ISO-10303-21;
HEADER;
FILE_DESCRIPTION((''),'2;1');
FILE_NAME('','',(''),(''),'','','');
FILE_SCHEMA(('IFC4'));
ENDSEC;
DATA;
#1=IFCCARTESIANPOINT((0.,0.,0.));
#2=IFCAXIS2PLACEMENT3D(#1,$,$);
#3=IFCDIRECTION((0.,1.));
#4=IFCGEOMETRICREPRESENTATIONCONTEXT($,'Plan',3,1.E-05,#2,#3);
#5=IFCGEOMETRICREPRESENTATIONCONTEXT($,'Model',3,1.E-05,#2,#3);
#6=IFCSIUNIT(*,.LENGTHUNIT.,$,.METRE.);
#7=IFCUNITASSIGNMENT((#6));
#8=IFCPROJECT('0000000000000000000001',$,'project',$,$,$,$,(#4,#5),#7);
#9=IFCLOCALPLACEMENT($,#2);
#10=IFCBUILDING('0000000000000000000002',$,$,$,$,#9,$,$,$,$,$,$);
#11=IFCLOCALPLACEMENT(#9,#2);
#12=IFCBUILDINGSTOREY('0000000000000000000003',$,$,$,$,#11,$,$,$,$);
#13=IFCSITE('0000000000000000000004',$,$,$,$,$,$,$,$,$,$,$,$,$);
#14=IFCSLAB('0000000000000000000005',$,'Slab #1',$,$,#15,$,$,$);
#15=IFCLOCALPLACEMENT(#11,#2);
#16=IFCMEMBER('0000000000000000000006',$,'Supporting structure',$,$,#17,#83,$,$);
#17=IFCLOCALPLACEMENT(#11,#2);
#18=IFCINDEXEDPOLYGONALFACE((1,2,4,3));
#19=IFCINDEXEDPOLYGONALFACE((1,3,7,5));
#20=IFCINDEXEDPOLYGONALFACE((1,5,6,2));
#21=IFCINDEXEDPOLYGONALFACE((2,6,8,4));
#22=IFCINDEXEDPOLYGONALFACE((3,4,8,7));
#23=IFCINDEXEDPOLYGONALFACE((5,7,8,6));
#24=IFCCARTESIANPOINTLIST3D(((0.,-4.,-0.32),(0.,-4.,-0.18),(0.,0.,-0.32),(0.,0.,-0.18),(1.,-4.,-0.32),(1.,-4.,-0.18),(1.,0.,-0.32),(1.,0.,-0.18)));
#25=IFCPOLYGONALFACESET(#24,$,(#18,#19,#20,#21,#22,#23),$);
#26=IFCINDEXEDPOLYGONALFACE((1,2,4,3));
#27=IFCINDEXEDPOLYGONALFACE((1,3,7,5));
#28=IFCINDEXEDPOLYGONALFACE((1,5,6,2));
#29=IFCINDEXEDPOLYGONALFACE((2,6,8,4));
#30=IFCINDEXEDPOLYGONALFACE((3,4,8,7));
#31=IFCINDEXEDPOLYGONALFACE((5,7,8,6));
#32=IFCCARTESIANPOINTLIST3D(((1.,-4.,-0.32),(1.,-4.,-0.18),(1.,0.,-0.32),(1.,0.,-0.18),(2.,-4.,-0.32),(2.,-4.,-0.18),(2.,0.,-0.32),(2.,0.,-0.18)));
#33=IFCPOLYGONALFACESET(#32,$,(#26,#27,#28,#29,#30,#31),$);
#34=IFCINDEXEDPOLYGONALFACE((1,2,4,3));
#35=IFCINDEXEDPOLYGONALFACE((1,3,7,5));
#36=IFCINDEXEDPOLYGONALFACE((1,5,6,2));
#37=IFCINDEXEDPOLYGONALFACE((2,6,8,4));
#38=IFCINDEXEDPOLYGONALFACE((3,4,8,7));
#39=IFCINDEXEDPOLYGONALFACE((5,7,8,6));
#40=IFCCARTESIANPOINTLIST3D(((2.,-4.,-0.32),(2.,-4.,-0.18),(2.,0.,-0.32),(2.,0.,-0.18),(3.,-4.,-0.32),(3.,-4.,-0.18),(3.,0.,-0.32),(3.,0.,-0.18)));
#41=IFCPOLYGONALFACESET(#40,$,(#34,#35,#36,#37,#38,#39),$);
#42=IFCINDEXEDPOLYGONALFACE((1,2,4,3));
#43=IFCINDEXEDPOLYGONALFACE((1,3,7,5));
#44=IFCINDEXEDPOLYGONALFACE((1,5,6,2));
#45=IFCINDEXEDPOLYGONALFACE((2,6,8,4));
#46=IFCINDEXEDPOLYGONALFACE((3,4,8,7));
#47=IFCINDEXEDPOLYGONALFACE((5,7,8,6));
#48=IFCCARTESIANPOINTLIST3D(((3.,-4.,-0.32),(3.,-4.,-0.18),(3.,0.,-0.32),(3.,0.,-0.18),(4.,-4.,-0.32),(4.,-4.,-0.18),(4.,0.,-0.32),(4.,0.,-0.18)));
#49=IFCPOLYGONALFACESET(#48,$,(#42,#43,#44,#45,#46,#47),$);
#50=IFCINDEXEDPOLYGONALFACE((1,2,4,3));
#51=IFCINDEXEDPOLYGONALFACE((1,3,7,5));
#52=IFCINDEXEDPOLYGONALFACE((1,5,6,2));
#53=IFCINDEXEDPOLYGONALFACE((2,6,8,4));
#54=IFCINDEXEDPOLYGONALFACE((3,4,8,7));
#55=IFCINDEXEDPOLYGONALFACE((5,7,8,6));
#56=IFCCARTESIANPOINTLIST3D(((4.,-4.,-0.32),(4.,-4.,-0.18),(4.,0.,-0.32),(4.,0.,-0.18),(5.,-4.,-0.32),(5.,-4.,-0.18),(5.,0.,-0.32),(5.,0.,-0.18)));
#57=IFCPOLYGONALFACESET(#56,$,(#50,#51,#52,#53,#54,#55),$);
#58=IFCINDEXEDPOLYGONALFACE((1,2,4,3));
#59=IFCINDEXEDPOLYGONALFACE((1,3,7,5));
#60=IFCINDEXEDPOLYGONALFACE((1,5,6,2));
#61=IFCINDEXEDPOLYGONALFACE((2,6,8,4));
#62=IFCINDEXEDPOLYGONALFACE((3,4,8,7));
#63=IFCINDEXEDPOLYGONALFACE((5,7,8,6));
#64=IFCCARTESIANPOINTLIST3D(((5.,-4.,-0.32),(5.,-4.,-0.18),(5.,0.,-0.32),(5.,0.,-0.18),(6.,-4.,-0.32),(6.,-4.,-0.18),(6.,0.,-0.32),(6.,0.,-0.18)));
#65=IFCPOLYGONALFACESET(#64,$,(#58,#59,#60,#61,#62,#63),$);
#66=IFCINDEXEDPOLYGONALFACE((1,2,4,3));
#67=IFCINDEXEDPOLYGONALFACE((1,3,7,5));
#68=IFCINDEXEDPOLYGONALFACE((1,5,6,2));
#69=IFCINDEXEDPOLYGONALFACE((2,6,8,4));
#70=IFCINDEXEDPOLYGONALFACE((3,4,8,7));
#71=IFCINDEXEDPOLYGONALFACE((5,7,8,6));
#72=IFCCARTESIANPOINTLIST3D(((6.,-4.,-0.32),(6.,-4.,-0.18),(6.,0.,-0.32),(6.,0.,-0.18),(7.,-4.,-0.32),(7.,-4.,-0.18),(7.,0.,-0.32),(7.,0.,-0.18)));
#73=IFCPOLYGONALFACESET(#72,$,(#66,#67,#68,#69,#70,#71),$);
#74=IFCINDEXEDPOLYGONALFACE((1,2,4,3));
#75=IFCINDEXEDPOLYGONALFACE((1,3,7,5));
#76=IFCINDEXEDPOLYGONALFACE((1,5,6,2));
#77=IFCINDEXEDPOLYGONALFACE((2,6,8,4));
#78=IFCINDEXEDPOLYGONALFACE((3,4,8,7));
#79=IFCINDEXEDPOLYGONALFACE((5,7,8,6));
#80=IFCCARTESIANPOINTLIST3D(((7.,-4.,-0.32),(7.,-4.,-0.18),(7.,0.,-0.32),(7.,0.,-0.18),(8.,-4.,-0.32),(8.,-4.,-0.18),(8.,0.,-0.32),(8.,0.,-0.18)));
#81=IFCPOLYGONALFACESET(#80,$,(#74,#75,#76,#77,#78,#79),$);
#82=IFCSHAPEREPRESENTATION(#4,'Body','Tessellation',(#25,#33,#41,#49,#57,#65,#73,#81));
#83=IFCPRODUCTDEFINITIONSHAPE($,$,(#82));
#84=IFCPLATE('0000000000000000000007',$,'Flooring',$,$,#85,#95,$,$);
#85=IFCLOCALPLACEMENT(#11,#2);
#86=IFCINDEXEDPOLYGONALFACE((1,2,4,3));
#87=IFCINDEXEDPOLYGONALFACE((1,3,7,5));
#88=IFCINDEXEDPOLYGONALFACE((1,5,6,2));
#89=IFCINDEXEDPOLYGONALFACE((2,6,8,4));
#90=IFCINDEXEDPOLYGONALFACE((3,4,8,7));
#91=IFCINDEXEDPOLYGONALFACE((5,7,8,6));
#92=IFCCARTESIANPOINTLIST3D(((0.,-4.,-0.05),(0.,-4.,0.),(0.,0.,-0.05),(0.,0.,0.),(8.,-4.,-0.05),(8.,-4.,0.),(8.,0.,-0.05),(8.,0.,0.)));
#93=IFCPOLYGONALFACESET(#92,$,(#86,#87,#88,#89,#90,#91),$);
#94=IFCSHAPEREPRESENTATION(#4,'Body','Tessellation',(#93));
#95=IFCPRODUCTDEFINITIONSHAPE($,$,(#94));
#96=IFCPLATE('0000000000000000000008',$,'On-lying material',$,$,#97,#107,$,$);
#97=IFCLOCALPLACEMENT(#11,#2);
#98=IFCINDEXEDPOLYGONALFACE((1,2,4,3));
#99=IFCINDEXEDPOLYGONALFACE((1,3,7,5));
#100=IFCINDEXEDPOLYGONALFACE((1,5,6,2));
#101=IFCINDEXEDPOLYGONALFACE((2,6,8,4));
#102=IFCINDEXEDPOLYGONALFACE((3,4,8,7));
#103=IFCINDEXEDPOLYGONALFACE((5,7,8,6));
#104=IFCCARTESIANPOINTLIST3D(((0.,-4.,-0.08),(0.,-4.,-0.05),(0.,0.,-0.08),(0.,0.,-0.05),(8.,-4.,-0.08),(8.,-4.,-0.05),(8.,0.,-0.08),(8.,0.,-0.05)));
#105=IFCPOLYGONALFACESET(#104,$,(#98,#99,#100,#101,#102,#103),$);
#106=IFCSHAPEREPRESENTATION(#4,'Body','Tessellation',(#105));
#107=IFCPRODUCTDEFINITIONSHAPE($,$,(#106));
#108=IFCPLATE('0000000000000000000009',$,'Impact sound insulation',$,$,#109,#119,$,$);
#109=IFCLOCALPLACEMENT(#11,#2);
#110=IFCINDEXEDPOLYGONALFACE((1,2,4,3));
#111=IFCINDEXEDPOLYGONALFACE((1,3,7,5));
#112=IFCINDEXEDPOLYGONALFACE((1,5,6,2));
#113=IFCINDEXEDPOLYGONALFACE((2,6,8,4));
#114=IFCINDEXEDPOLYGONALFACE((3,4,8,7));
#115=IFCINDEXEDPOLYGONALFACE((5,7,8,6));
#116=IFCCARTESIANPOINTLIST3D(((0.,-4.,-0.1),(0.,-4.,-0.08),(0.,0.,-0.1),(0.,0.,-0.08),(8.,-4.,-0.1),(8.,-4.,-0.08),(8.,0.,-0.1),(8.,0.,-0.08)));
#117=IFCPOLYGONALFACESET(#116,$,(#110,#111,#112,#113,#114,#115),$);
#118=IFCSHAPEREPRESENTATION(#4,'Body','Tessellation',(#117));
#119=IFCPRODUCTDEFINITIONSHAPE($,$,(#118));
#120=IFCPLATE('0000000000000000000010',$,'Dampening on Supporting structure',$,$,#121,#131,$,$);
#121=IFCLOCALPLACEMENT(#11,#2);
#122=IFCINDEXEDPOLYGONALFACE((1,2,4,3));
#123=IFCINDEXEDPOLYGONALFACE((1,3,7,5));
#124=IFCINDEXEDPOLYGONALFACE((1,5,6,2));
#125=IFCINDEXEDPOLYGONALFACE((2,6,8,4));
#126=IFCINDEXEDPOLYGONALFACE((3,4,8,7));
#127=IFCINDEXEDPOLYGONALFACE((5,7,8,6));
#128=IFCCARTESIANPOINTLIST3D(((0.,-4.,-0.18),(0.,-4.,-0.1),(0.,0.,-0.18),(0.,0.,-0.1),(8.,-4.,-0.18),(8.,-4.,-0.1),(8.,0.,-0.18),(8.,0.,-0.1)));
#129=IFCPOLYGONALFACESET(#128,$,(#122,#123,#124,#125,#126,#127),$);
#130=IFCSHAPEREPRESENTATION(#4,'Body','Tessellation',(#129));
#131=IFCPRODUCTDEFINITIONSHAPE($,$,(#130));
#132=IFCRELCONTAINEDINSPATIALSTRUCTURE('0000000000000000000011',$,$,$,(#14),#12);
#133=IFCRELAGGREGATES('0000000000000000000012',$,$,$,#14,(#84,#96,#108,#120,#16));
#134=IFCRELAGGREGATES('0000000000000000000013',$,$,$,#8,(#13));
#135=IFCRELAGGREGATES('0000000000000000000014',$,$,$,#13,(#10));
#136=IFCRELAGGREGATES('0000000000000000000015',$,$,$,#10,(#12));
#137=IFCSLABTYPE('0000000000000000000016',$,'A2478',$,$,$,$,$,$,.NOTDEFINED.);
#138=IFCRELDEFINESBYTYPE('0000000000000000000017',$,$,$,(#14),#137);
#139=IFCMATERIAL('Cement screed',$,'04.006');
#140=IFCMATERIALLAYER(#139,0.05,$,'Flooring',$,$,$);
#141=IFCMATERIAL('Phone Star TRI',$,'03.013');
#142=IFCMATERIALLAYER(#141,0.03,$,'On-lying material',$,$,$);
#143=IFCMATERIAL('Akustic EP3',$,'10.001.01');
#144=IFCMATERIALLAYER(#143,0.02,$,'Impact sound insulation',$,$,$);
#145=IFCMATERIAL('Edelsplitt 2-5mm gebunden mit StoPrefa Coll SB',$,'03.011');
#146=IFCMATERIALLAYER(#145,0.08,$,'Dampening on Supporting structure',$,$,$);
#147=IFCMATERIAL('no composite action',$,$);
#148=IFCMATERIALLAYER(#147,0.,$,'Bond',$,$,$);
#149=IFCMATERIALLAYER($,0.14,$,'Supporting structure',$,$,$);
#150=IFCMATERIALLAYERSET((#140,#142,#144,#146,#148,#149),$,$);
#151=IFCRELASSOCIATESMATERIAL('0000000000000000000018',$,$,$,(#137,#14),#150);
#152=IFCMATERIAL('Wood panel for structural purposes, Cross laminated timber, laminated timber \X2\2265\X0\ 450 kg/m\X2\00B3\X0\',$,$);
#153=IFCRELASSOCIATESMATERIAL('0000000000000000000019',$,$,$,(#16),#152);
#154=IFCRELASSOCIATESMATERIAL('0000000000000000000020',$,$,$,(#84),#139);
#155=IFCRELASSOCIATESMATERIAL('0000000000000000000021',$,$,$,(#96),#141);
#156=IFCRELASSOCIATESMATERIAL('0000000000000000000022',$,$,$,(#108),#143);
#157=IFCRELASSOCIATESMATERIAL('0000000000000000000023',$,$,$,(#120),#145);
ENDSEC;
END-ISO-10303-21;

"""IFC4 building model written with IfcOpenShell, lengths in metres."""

from ifc_helpers import new_model, si_unit, direction, frame, frame_2d, origin, origin_with_axes, place, context, project, spatial, rectangle, extrude, material, layer, layer_set, type_object, element, aggregate, save


model = new_model("IFC4")

# Units and contexts
plan_context = context("Plan", 3, precision=1e-05, world=origin(), true_north=direction((0.0, 1.0)))
model_context = context("Model", 3, precision=1e-05, world=origin(), true_north=direction((0.0, 1.0)))
ifc_project = project(units=[si_unit("LENGTHUNIT", "METRE")], contexts=[plan_context, model_context])

# Site, building, storey
site = spatial("IfcSite", under=ifc_project)
building_placement = place(None, origin())
building = spatial("IfcBuilding", under=site, at=building_placement)
storey_placement = place(building_placement, origin())
storey = spatial("IfcBuildingStorey", under=building, at=storey_placement)

# Slab, member, plates
ifc_material_1 = material(Name="Cement screed", Category="04.006")
ifc_layer_1 = layer(ifc_material_1, 0.05, Name="Flooring")
ifc_material_2 = material(Name="Phone Star TRI", Category="03.013")
ifc_layer_2 = layer(ifc_material_2, 0.03, Name="On-lying material")
ifc_material_3 = material(Name="Akustic EP3", Category="10.001.01")
ifc_layer_3 = layer(ifc_material_3, 0.02, Name="Impact sound insulation")
ifc_material_4 = material(Name="Edelsplitt 2-5mm gebunden mit StoPrefa Coll SB", Category="03.011")
ifc_layer_4 = layer(ifc_material_4, 0.08, Name="Dampening on Supporting structure")
ifc_material_5 = material(Name="no composite action")
ifc_layer_5 = layer(ifc_material_5, 0.0, Name="Bond")
ifc_layer_6 = layer(None, 0.14, Name="Supporting structure")
ifc_layer_set = layer_set([ifc_layer_1, ifc_layer_2, ifc_layer_3, ifc_layer_4, ifc_layer_5, ifc_layer_6])
slab_type = type_object("IfcSlabType", Name="A2478", PredefinedType="NOTDEFINED", material=ifc_layer_set)
slab_placement = place(None, frame((0.0, 0.0, 0.0), z_axis=(0.0, 0.0, -1.0), x_axis=(1.0, 0.0, 0.0)))
slab = element("IfcSlab", 1, at=slab_placement, inside=storey, type_object=slab_type, material=ifc_layer_set, Name="Slab #1")
ifc_material_6 = material(Name="Wood panel for structural purposes, Cross laminated timber, laminated timber ≥ 450 kg/m³")
member_placement = place(slab_placement, origin())
member = element("IfcMember", 2, at=member_placement, material=ifc_material_6, Name="Supporting structure", context=plan_context, shape_type="SweptSolid", body=[
    extrude(rectangle(XDim=1.0, YDim=0.14, at=frame_2d((0.5, 0.07), x_axis=(1.0, 0.0))), frame((0.0, 4.0, 0.18), z_axis=(0.0, -1.0, 0.0), x_axis=(1.0, 0.0, 0.0)), (0.0, 0.0, 1.0), 4.0),
    extrude(rectangle(XDim=1.0, YDim=0.14, at=frame_2d((0.5, 0.07), x_axis=(1.0, 0.0))), frame((1.0, 4.0, 0.18), z_axis=(0.0, -1.0, 0.0), x_axis=(1.0, 0.0, 0.0)), (0.0, 0.0, 1.0), 4.0),
    extrude(rectangle(XDim=1.0, YDim=0.14, at=frame_2d((0.5, 0.07), x_axis=(1.0, 0.0))), frame((2.0, 4.0, 0.18), z_axis=(0.0, -1.0, 0.0), x_axis=(1.0, 0.0, 0.0)), (0.0, 0.0, 1.0), 4.0),
    extrude(rectangle(XDim=1.0, YDim=0.14, at=frame_2d((0.5, 0.07), x_axis=(1.0, 0.0))), frame((3.0, 4.0, 0.18), z_axis=(0.0, -1.0, 0.0), x_axis=(1.0, 0.0, 0.0)), (0.0, 0.0, 1.0), 4.0),
    extrude(rectangle(XDim=1.0, YDim=0.14, at=frame_2d((0.5, 0.07), x_axis=(1.0, 0.0))), frame((4.0, 4.0, 0.18), z_axis=(0.0, -1.0, 0.0), x_axis=(1.0, 0.0, 0.0)), (0.0, 0.0, 1.0), 4.0),
    extrude(rectangle(XDim=1.0, YDim=0.14, at=frame_2d((0.5, 0.07), x_axis=(1.0, 0.0))), frame((5.0, 4.0, 0.18), z_axis=(0.0, -1.0, 0.0), x_axis=(1.0, 0.0, 0.0)), (0.0, 0.0, 1.0), 4.0),
    extrude(rectangle(XDim=1.0, YDim=0.14, at=frame_2d((0.5, 0.07), x_axis=(1.0, 0.0))), frame((6.0, 4.0, 0.18), z_axis=(0.0, -1.0, 0.0), x_axis=(1.0, 0.0, 0.0)), (0.0, 0.0, 1.0), 4.0),
    extrude(rectangle(XDim=1.0, YDim=0.14, at=frame_2d((0.5, 0.07), x_axis=(1.0, 0.0))), frame((7.0, 4.0, 0.18), z_axis=(0.0, -1.0, 0.0), x_axis=(1.0, 0.0, 0.0)), (0.0, 0.0, 1.0), 4.0),
])
plate_1_placement = place(slab_placement, origin())
plate_1 = element("IfcPlate", 3, at=plate_1_placement, material=ifc_material_1, Name="Flooring", context=plan_context, shape_type="SweptSolid", body=[
    extrude(rectangle(XDim=8.0, YDim=4.0, at=frame_2d((4.0, 2.0), x_axis=(1.0, 0.0))), origin_with_axes(), (0.0, 0.0, 1.0), 0.05),
])
plate_2_placement = place(slab_placement, origin())
plate_2 = element("IfcPlate", 4, at=plate_2_placement, material=ifc_material_2, Name="On-lying material", context=plan_context, shape_type="SweptSolid", body=[
    extrude(rectangle(XDim=8.0, YDim=4.0, at=frame_2d((4.0, 2.0), x_axis=(1.0, 0.0))), frame((0.0, 0.0, 0.05), z_axis=(0.0, 0.0, 1.0), x_axis=(1.0, 0.0, 0.0)), (0.0, 0.0, 1.0), 0.03),
])
plate_3_placement = place(slab_placement, origin())
plate_3 = element("IfcPlate", 5, at=plate_3_placement, material=ifc_material_3, Name="Impact sound insulation", context=plan_context, shape_type="SweptSolid", body=[
    extrude(rectangle(XDim=8.0, YDim=4.0, at=frame_2d((4.0, 2.0), x_axis=(1.0, 0.0))), frame((0.0, 0.0, 0.08), z_axis=(0.0, 0.0, 1.0), x_axis=(1.0, 0.0, 0.0)), (0.0, 0.0, 1.0), 0.02),
])
plate_4_placement = place(slab_placement, origin())
plate_4 = element("IfcPlate", 6, at=plate_4_placement, material=ifc_material_4, Name="Dampening on Supporting structure", context=plan_context, shape_type="SweptSolid", body=[
    extrude(rectangle(XDim=8.0, YDim=4.0, at=frame_2d((4.0, 2.0), x_axis=(1.0, 0.0))), frame((0.0, 0.0, 0.1), z_axis=(0.0, 0.0, 1.0), x_axis=(1.0, 0.0, 0.0)), (0.0, 0.0, 1.0), 0.08),
])
aggregate(slab, [plate_1, plate_2, plate_3, plate_4, member])

save(model, "model.ifc")
